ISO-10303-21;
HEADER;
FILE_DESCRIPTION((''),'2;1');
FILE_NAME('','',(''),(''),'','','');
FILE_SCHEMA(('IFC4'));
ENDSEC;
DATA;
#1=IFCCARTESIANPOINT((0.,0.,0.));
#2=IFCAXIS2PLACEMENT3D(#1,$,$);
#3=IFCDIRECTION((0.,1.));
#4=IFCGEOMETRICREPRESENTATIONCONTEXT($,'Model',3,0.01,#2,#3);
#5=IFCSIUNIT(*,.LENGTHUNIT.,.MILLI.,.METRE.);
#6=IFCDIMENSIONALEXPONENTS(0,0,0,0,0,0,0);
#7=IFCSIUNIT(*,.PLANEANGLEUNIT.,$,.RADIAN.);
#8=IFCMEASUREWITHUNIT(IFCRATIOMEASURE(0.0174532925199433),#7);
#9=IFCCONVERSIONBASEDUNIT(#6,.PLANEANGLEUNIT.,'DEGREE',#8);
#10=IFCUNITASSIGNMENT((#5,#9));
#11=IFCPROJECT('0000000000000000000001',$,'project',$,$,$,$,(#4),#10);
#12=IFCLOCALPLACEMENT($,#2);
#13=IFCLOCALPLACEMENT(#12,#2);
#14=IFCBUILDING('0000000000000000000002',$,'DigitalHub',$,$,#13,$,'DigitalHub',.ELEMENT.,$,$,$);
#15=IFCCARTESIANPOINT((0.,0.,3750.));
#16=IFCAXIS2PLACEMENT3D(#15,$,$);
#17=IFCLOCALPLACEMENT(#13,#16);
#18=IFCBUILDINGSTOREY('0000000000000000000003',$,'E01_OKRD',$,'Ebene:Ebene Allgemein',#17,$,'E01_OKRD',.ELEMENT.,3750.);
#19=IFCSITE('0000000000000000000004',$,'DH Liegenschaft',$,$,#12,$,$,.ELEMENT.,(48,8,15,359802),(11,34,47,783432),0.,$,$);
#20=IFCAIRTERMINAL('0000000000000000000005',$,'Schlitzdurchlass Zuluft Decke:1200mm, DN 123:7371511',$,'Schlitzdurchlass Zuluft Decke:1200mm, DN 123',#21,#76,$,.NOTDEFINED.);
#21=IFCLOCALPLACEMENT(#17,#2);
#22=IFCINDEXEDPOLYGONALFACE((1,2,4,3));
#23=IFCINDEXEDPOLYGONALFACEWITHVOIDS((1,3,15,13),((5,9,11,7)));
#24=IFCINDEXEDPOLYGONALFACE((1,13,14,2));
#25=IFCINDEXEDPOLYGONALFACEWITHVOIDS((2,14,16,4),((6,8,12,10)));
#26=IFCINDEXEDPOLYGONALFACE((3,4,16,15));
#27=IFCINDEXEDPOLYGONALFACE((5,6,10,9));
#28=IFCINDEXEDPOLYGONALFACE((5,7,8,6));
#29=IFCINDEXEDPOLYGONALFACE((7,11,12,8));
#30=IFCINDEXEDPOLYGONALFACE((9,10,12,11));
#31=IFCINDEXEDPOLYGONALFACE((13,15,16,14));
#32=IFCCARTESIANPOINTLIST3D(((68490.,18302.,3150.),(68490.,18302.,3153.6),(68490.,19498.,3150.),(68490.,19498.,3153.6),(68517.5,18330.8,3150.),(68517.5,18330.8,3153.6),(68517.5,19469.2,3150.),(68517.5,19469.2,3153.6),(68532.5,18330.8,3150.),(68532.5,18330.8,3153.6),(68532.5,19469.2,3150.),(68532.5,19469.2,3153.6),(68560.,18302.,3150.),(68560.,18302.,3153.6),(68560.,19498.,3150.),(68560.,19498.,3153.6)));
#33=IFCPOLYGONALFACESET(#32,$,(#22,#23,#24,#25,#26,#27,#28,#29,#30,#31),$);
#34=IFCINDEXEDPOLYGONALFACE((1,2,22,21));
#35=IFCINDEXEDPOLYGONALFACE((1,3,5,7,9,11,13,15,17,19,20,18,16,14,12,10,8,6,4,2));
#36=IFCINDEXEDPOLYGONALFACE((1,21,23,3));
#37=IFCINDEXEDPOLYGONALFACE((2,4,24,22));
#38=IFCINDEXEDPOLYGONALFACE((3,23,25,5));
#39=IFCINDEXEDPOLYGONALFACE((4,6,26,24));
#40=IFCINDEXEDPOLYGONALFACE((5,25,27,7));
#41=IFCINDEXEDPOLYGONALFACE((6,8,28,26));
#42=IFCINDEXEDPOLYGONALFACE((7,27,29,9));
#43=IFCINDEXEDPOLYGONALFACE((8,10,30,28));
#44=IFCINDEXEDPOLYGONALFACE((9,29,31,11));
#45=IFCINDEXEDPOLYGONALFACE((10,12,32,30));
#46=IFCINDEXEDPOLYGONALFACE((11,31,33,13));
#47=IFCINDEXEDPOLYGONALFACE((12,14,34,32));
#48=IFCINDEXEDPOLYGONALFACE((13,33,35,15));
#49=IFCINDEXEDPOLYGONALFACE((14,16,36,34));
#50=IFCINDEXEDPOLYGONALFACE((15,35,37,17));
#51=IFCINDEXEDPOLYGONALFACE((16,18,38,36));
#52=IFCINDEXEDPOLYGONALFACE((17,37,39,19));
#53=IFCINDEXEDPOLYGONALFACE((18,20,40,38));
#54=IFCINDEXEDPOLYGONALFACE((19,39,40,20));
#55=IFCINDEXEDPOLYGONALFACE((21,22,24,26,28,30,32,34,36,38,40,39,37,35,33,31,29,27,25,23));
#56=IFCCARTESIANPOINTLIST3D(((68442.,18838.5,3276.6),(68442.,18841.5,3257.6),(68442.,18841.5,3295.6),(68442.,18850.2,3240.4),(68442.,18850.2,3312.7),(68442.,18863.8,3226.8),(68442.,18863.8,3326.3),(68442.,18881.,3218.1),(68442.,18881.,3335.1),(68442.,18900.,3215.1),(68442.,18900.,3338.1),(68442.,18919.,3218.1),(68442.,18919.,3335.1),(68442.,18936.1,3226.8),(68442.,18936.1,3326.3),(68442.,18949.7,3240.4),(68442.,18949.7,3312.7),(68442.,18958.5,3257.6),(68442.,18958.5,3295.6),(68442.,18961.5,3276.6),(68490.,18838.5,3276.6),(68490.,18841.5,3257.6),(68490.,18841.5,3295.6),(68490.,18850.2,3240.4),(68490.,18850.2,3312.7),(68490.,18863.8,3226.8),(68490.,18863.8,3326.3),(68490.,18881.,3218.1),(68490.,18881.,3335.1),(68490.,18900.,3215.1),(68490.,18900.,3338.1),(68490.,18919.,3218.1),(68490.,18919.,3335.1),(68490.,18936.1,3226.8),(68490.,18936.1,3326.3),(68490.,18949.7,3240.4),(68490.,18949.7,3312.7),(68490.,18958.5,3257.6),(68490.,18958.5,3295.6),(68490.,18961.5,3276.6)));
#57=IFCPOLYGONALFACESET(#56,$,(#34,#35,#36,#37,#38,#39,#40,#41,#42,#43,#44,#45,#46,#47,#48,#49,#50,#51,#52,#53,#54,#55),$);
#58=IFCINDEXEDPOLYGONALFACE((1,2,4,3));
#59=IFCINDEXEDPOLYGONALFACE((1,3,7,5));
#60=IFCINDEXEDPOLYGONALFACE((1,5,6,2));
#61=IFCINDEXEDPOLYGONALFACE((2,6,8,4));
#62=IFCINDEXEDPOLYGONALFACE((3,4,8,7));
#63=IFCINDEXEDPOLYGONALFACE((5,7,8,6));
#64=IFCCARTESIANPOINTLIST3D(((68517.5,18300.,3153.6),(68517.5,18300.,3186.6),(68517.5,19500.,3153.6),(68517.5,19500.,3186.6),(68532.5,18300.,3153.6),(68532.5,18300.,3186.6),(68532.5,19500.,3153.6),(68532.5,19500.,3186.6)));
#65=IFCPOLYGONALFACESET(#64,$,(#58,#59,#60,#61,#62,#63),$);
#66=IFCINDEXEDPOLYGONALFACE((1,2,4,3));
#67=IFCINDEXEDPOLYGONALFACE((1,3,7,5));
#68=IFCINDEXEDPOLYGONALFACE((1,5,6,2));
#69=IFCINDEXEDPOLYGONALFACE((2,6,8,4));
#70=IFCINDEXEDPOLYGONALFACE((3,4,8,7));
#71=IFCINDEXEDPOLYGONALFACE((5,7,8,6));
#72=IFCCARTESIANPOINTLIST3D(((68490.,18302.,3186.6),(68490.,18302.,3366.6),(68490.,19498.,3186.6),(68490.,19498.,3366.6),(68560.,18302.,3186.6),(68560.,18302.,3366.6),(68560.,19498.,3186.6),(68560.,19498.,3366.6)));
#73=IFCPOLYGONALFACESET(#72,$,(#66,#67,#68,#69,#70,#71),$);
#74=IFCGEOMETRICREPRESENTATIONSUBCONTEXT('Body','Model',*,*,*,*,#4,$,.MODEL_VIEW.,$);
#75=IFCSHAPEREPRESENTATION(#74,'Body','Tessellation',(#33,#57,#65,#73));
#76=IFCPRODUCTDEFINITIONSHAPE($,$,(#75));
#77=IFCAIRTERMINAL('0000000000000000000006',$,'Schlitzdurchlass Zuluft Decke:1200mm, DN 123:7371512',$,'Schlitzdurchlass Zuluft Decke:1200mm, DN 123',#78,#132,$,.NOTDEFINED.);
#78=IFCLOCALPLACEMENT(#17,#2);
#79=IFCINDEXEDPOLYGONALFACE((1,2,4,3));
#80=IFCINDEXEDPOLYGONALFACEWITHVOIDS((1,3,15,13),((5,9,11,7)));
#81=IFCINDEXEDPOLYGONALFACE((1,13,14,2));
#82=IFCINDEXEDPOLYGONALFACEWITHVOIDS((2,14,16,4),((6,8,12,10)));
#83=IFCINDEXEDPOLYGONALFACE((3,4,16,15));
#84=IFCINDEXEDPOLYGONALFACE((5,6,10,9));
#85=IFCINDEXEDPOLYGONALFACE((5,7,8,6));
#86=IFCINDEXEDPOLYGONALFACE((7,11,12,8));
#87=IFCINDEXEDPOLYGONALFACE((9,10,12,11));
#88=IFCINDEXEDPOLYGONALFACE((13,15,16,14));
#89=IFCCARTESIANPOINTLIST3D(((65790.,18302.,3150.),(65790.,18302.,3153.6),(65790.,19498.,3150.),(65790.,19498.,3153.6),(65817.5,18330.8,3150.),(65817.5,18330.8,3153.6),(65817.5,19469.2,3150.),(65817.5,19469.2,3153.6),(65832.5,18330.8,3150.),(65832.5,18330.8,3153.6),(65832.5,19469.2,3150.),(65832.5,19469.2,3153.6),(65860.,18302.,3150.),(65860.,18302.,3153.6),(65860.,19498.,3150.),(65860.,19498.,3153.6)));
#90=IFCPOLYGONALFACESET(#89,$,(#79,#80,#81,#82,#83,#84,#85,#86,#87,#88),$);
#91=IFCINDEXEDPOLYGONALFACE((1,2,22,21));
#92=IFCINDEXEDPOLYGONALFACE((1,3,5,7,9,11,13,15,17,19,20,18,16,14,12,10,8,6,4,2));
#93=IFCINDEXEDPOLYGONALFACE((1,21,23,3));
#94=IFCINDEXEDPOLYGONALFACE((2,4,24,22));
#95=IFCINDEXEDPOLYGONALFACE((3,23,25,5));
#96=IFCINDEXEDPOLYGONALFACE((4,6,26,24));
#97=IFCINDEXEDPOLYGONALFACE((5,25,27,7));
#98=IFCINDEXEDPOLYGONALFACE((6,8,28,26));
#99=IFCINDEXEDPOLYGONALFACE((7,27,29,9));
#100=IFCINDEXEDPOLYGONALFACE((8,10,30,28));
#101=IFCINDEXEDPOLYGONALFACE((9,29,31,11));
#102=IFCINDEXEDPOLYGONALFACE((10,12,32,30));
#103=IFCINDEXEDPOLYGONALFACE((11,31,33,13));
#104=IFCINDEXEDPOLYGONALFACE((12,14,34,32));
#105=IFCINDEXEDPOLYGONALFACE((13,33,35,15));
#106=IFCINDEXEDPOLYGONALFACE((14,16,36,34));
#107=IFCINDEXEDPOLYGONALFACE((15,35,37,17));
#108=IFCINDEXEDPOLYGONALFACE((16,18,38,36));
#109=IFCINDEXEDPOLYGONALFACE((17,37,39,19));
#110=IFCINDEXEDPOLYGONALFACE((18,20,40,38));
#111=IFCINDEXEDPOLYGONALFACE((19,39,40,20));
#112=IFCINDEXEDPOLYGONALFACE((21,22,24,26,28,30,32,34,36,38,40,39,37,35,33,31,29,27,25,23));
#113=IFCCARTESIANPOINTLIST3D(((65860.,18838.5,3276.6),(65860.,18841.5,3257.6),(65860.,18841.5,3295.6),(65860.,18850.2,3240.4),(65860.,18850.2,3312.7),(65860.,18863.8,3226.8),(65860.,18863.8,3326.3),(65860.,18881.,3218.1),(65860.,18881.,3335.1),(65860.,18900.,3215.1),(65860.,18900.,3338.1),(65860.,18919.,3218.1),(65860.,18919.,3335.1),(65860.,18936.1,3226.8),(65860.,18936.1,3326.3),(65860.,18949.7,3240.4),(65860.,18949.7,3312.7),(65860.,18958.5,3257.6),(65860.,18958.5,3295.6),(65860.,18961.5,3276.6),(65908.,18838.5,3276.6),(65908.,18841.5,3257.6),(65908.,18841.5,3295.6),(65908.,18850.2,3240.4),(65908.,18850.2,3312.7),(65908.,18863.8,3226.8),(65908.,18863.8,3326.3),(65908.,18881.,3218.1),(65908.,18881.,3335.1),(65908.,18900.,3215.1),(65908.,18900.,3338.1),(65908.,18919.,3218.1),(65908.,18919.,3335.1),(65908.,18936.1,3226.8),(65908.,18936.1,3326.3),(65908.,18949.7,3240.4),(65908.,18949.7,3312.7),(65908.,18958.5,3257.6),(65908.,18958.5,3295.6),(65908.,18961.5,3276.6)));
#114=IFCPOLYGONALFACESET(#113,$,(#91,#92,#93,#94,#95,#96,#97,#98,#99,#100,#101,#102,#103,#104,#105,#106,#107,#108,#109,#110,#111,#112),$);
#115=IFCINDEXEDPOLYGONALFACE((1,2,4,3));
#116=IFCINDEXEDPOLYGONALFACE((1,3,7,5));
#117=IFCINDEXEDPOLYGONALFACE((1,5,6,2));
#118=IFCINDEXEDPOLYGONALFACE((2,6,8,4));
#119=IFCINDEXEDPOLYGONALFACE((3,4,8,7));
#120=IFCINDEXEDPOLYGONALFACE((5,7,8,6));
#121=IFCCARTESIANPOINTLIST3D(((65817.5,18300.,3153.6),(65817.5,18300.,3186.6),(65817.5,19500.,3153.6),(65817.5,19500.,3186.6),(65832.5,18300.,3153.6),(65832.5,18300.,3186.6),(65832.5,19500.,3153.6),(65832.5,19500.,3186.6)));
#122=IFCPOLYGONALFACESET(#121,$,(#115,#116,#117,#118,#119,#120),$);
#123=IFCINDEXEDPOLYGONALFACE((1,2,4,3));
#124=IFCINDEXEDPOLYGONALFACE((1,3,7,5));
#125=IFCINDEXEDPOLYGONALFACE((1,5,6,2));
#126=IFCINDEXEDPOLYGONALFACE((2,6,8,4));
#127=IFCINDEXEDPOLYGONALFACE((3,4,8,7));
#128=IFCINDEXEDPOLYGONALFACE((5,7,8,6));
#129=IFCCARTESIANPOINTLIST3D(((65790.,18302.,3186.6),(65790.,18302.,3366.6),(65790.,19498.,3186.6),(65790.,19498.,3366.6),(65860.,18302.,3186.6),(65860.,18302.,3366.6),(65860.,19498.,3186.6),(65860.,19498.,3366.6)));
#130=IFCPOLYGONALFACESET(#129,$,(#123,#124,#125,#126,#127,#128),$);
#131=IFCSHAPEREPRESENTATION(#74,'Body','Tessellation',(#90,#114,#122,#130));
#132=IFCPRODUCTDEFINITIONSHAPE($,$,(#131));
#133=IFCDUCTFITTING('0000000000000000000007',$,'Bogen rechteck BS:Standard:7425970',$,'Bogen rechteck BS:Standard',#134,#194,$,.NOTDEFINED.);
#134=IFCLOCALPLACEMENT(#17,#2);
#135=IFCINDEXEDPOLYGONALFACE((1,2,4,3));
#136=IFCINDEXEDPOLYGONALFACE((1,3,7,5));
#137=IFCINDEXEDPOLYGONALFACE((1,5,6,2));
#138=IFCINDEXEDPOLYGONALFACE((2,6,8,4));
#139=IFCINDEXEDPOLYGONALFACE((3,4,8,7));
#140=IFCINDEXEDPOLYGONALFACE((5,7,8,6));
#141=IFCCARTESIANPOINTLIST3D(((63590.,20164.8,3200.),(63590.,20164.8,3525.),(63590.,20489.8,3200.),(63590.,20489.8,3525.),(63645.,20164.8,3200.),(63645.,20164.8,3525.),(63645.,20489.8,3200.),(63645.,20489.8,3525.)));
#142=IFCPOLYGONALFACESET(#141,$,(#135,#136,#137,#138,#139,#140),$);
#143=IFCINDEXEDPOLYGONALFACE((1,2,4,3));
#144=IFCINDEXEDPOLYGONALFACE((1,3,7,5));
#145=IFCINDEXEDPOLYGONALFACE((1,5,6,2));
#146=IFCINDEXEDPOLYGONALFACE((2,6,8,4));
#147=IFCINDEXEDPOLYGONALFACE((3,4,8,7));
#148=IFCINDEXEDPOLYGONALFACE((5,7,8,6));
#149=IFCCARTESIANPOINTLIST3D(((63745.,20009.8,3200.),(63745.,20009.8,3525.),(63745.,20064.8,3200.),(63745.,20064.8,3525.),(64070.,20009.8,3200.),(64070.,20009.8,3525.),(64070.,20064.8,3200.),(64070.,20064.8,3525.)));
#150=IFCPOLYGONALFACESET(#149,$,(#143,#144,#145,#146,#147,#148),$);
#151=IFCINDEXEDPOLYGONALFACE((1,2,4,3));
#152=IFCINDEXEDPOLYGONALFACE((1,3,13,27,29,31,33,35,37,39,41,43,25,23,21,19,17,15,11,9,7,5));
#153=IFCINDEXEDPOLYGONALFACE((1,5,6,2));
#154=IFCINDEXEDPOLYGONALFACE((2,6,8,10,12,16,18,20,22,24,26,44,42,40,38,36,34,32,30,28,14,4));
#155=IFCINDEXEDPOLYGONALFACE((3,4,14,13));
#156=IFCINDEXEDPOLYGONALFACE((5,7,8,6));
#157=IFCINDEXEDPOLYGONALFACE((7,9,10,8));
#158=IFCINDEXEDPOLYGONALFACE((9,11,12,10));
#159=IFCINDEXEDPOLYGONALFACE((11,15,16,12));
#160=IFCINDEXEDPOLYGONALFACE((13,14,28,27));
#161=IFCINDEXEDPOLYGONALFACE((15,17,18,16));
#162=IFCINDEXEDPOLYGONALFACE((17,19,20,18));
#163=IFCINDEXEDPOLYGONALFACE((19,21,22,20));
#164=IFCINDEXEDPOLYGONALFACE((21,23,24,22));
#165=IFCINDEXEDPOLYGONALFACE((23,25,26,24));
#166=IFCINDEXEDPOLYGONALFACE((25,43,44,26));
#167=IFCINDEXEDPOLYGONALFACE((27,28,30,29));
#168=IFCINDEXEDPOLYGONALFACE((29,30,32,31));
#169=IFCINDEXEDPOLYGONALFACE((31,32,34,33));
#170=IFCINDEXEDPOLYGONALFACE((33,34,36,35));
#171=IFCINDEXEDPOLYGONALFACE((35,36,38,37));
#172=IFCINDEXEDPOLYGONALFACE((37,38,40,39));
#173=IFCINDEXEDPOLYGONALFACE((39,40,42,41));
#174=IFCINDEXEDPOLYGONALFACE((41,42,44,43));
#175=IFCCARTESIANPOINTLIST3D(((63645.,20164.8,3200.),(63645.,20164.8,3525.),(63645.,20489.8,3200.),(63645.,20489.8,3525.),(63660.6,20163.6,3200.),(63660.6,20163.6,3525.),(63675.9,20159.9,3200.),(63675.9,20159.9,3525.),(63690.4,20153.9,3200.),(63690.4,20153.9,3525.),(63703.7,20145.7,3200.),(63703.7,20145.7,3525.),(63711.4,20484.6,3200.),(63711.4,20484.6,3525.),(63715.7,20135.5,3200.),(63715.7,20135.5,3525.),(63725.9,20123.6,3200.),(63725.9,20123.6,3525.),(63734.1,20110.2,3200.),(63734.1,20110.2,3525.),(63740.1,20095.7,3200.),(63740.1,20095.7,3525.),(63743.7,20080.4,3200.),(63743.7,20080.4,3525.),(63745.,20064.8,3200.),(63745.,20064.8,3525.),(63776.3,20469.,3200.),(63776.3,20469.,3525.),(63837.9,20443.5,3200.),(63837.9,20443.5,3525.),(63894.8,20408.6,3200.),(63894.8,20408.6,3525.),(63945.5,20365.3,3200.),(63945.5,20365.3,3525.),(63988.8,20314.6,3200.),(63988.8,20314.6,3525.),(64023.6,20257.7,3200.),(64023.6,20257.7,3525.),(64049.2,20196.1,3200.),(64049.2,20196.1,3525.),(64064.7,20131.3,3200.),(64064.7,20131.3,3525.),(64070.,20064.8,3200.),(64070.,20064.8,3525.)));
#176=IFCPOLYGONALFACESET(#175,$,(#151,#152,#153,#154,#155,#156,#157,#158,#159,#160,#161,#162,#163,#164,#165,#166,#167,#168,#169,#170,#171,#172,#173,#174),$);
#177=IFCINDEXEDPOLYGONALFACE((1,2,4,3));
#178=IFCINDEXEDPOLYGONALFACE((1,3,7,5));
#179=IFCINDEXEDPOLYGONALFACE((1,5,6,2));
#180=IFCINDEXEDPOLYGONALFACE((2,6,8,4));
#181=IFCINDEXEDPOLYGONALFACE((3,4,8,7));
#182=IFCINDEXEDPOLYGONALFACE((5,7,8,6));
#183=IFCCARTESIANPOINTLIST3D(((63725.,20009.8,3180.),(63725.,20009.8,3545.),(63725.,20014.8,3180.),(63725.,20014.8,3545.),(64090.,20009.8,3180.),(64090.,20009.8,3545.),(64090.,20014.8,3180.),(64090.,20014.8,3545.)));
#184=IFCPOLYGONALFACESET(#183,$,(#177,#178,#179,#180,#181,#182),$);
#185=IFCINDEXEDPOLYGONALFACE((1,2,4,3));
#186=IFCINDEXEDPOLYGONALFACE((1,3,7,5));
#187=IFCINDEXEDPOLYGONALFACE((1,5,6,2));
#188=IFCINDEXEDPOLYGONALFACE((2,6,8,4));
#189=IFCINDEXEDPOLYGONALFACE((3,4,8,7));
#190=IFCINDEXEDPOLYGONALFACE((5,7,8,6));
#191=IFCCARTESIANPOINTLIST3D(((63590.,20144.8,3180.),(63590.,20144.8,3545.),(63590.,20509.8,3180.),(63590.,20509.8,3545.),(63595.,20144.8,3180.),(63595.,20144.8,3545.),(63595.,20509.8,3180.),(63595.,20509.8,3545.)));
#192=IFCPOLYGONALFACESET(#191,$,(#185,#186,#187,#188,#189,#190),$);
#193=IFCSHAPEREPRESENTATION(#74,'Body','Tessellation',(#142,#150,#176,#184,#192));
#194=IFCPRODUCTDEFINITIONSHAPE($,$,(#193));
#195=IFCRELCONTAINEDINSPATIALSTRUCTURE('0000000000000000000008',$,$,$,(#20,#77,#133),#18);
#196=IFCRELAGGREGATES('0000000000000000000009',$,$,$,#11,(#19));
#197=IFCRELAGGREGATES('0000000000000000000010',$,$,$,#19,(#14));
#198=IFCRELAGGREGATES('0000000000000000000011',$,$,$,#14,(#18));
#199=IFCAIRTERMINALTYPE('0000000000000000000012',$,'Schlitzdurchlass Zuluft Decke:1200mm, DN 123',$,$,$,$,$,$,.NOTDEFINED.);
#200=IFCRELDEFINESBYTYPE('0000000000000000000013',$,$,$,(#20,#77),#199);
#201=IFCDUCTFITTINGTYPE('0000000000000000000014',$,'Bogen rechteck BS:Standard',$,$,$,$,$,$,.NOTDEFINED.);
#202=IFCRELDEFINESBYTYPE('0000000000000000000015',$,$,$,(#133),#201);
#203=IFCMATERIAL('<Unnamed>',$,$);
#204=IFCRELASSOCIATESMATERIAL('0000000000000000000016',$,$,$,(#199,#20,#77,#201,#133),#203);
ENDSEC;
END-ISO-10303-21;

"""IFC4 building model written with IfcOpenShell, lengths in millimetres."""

from ifc_helpers import new_model, entity, si_unit, converted_unit, direction, frame, origin, place, context, subcontext, project, spatial, indexed_curve, outline, extrude, source, transform, mapped, material, type_object, type_shapes, element, save


model = new_model("IFC4")

# Units and contexts
model_context = context("Model", 3, precision=0.01, world=origin(), true_north=direction((0.0, 1.0)))
body_context = subcontext(model_context, "Body", "Model", "MODEL_VIEW")
ifc_project = project(units=[si_unit("LENGTHUNIT", "METRE", prefix="MILLI"), converted_unit("PLANEANGLEUNIT", "DEGREE", entity("IfcRatioMeasure", 0.0174532925199433), si_unit("PLANEANGLEUNIT", "RADIAN"), dimensions=[0, 0, 0, 0, 0, 0, 0])], contexts=[model_context])

# Site, building, storey
site_placement = place(None, origin())
site = spatial("IfcSite", under=ifc_project, at=site_placement, Name="DH Liegenschaft", CompositionType="ELEMENT", RefLatitude=(48, 8, 15, 359802), RefLongitude=(11, 34, 47, 783432), RefElevation=0.0)
building_placement = place(site_placement, origin())
building = spatial("IfcBuilding", under=site, at=building_placement, Name="DigitalHub", LongName="DigitalHub", CompositionType="ELEMENT")
storey_placement = place(building_placement, frame((0.0, 0.0, 3750.0)))
storey = spatial("IfcBuildingStorey", under=building, at=storey_placement, Name="E01_OKRD", ObjectType="Ebene:Ebene Allgemein", LongName="E01_OKRD", CompositionType="ELEMENT", Elevation=3750.0)

# Shared definitions
ifc_material_1 = material(Name="<Unnamed>")

# Air terminals
air_terminal_type_1 = type_object("IfcAirTerminalType", Name="Schlitzdurchlass Zuluft Decke:1200mm, DN 123", PredefinedType="NOTDEFINED", material=ifc_material_1)
shared_shape_1 = source(origin(), body_context, "Body", "SweptSolid", [
    extrude(outline(indexed_curve([(-598.0, -35.0), (598.0, -35.0), (598.0, 35.0), (-598.0, 35.0), (-598.0, -35.0)], self_intersect=False), holes=[indexed_curve([(-569.2, -7.5), (-569.2, 7.5), (569.2, 7.5), (569.2, -7.5), (-569.2, -7.5)], self_intersect=False)]), frame((600.0, 35.0, 0.0), z_axis=(0.0, 0.0, 1.0), x_axis=(-1.0, 0.0, 0.0)), (0.0, 0.0, 1.0), 3.6),
    extrude(outline(indexed_curve([(61.5, 0.0), (58.5, 19.0), (49.8, 36.1), (36.1, 49.8), (19.0, 58.5), (0.0, 61.5), (-19.0, 58.5), (-36.1, 49.8), (-49.8, 36.1), (-58.5, 19.0), (-61.5, 0.0), (-58.5, -19.0), (-49.8, -36.1), (-36.1, -49.8), (-19.0, -58.5), (0.0, -61.5), (19.0, -58.5), (36.1, -49.8), (49.8, -36.1), (58.5, -19.0), (61.5, 0.0)], self_intersect=False)), frame((600.0, 70.0, 126.6), z_axis=(0.0, 1.0, 0.0), x_axis=(-1.0, 0.0, 0.0)), (0.0, 0.0, 1.0), 48.0),
    extrude(outline(indexed_curve([(-600.0, -7.5), (600.0, -7.5), (600.0, 7.5), (-600.0, 7.5), (-600.0, -7.5)], self_intersect=False)), frame((600.0, 35.0, 3.6), z_axis=(0.0, 0.0, 1.0), x_axis=(-1.0, 0.0, 0.0)), (0.0, 0.0, 1.0), 33.0),
    extrude(outline(indexed_curve([(-598.0, -35.0), (598.0, -35.0), (598.0, 35.0), (-598.0, 35.0), (-598.0, -35.0)], self_intersect=False)), frame((600.0, 35.0, 36.6), z_axis=(0.0, 0.0, 1.0), x_axis=(-1.0, 0.0, 0.0)), (0.0, 0.0, 1.0), 180.0),
])
type_shapes(air_terminal_type_1, [shared_shape_1])
for number, where, z_axis, x_axis, name in (
    (1, (68560.0, 18300.0, 3150.0), (0.0, 0.0, 1.0), (0.0, 1.0, 0.0), "Schlitzdurchlass Zuluft Decke:1200mm, DN 123:7371511"),
    (2, (65790.0, 19500.0, 3150.0), (0.0, 0.0, 1.0), (0.0, -1.0, 0.0), "Schlitzdurchlass Zuluft Decke:1200mm, DN 123:7371512"),
):
    element("IfcAirTerminal", number, at=place(storey_placement, frame(where, z_axis=z_axis, x_axis=x_axis)), inside=storey, type_object=air_terminal_type_1, material=ifc_material_1, Name=name, ObjectType="Schlitzdurchlass Zuluft Decke:1200mm, DN 123", PredefinedType="NOTDEFINED", context=body_context, shape_type="MappedRepresentation", body=[
        mapped(shared_shape_1, transform((0.0, 0.0, 0.0), scale=1.0)),
    ])

# Duct fitting
duct_fitting_type_1 = type_object("IfcDuctFittingType", Name="Bogen rechteck BS:Standard", PredefinedType="NOTDEFINED", material=ifc_material_1)
shared_shape_2 = source(origin(), body_context, "Body", "SweptSolid", [
    extrude(outline(indexed_curve([(-27.5, -162.5), (27.5, -162.5), (27.5, 162.5), (-27.5, 162.5), (-27.5, -162.5)], self_intersect=False)), frame((0.0, 290.0, -162.5), z_axis=(0.0, 0.0, 1.0), x_axis=(0.0, 1.0, 0.0)), (0.0, 0.0, 1.0), 325.0),
    extrude(outline(indexed_curve([(-162.5, -27.5), (162.5, -27.5), (162.5, 27.5), (-162.5, 27.5), (-162.5, -27.5)], self_intersect=False)), frame((-290.0, 0.0, -162.5), z_axis=(0.0, 0.0, 1.0), x_axis=(0.0, -1.0, 0.0)), (0.0, 0.0, 1.0), 325.0),
    extrude(outline(indexed_curve([(-293.8, -131.2), (31.2, -131.2), (32.5, -115.6), (36.1, -100.3), (42.1, -85.9), (50.3, -72.5), (60.5, -60.5), (72.5, -50.3), (85.9, -42.1), (100.3, -36.1), (115.6, -32.5), (131.2, -31.2), (131.2, 293.8), (64.8, 288.5), (-0.1, 272.9), (-61.7, 247.4), (-118.6, 212.6), (-169.3, 169.3), (-212.6, 118.6), (-247.4, 61.7), (-272.9, 0.1), (-288.5, -64.8), (-293.8, -131.2)], self_intersect=False)), frame((-131.2, 131.3, -162.5), z_axis=(0.0, 0.0, 1.0), x_axis=(-1.0, 0.0, 0.0)), (0.0, 0.0, 1.0), 325.0),
    extrude(outline(indexed_curve([(-2.5, -182.5), (2.5, -182.5), (2.5, 182.5), (-2.5, 182.5), (-2.5, -182.5)], self_intersect=False)), frame((-315.0, 0.0, -182.5)), (0.0, 0.0, 1.0), 365.0),
    extrude(outline(indexed_curve([(-2.5, -182.5), (2.5, -182.5), (2.5, 182.5), (-2.5, 182.5), (-2.5, -182.5)], self_intersect=False)), frame((0.0, 315.0, -182.5), z_axis=(0.0, 0.0, 1.0), x_axis=(0.0, 1.0, 0.0)), (0.0, 0.0, 1.0), 365.0),
])
type_shapes(duct_fitting_type_1, [shared_shape_2])
duct_fitting_1_placement = place(storey_placement, frame((63907.5, 20327.3, 3362.5), z_axis=(0.0, 0.0, 1.0), x_axis=(0.0, 1.0, 0.0)))
element("IfcDuctFitting", 3, at=duct_fitting_1_placement, inside=storey, type_object=duct_fitting_type_1, material=ifc_material_1, Name="Bogen rechteck BS:Standard:7425970", ObjectType="Bogen rechteck BS:Standard", PredefinedType="NOTDEFINED", context=body_context, shape_type="MappedRepresentation", body=[
    mapped(shared_shape_2, transform((0.0, 0.0, 0.0), scale=1.0)),
])

save(model, "model.ifc")
